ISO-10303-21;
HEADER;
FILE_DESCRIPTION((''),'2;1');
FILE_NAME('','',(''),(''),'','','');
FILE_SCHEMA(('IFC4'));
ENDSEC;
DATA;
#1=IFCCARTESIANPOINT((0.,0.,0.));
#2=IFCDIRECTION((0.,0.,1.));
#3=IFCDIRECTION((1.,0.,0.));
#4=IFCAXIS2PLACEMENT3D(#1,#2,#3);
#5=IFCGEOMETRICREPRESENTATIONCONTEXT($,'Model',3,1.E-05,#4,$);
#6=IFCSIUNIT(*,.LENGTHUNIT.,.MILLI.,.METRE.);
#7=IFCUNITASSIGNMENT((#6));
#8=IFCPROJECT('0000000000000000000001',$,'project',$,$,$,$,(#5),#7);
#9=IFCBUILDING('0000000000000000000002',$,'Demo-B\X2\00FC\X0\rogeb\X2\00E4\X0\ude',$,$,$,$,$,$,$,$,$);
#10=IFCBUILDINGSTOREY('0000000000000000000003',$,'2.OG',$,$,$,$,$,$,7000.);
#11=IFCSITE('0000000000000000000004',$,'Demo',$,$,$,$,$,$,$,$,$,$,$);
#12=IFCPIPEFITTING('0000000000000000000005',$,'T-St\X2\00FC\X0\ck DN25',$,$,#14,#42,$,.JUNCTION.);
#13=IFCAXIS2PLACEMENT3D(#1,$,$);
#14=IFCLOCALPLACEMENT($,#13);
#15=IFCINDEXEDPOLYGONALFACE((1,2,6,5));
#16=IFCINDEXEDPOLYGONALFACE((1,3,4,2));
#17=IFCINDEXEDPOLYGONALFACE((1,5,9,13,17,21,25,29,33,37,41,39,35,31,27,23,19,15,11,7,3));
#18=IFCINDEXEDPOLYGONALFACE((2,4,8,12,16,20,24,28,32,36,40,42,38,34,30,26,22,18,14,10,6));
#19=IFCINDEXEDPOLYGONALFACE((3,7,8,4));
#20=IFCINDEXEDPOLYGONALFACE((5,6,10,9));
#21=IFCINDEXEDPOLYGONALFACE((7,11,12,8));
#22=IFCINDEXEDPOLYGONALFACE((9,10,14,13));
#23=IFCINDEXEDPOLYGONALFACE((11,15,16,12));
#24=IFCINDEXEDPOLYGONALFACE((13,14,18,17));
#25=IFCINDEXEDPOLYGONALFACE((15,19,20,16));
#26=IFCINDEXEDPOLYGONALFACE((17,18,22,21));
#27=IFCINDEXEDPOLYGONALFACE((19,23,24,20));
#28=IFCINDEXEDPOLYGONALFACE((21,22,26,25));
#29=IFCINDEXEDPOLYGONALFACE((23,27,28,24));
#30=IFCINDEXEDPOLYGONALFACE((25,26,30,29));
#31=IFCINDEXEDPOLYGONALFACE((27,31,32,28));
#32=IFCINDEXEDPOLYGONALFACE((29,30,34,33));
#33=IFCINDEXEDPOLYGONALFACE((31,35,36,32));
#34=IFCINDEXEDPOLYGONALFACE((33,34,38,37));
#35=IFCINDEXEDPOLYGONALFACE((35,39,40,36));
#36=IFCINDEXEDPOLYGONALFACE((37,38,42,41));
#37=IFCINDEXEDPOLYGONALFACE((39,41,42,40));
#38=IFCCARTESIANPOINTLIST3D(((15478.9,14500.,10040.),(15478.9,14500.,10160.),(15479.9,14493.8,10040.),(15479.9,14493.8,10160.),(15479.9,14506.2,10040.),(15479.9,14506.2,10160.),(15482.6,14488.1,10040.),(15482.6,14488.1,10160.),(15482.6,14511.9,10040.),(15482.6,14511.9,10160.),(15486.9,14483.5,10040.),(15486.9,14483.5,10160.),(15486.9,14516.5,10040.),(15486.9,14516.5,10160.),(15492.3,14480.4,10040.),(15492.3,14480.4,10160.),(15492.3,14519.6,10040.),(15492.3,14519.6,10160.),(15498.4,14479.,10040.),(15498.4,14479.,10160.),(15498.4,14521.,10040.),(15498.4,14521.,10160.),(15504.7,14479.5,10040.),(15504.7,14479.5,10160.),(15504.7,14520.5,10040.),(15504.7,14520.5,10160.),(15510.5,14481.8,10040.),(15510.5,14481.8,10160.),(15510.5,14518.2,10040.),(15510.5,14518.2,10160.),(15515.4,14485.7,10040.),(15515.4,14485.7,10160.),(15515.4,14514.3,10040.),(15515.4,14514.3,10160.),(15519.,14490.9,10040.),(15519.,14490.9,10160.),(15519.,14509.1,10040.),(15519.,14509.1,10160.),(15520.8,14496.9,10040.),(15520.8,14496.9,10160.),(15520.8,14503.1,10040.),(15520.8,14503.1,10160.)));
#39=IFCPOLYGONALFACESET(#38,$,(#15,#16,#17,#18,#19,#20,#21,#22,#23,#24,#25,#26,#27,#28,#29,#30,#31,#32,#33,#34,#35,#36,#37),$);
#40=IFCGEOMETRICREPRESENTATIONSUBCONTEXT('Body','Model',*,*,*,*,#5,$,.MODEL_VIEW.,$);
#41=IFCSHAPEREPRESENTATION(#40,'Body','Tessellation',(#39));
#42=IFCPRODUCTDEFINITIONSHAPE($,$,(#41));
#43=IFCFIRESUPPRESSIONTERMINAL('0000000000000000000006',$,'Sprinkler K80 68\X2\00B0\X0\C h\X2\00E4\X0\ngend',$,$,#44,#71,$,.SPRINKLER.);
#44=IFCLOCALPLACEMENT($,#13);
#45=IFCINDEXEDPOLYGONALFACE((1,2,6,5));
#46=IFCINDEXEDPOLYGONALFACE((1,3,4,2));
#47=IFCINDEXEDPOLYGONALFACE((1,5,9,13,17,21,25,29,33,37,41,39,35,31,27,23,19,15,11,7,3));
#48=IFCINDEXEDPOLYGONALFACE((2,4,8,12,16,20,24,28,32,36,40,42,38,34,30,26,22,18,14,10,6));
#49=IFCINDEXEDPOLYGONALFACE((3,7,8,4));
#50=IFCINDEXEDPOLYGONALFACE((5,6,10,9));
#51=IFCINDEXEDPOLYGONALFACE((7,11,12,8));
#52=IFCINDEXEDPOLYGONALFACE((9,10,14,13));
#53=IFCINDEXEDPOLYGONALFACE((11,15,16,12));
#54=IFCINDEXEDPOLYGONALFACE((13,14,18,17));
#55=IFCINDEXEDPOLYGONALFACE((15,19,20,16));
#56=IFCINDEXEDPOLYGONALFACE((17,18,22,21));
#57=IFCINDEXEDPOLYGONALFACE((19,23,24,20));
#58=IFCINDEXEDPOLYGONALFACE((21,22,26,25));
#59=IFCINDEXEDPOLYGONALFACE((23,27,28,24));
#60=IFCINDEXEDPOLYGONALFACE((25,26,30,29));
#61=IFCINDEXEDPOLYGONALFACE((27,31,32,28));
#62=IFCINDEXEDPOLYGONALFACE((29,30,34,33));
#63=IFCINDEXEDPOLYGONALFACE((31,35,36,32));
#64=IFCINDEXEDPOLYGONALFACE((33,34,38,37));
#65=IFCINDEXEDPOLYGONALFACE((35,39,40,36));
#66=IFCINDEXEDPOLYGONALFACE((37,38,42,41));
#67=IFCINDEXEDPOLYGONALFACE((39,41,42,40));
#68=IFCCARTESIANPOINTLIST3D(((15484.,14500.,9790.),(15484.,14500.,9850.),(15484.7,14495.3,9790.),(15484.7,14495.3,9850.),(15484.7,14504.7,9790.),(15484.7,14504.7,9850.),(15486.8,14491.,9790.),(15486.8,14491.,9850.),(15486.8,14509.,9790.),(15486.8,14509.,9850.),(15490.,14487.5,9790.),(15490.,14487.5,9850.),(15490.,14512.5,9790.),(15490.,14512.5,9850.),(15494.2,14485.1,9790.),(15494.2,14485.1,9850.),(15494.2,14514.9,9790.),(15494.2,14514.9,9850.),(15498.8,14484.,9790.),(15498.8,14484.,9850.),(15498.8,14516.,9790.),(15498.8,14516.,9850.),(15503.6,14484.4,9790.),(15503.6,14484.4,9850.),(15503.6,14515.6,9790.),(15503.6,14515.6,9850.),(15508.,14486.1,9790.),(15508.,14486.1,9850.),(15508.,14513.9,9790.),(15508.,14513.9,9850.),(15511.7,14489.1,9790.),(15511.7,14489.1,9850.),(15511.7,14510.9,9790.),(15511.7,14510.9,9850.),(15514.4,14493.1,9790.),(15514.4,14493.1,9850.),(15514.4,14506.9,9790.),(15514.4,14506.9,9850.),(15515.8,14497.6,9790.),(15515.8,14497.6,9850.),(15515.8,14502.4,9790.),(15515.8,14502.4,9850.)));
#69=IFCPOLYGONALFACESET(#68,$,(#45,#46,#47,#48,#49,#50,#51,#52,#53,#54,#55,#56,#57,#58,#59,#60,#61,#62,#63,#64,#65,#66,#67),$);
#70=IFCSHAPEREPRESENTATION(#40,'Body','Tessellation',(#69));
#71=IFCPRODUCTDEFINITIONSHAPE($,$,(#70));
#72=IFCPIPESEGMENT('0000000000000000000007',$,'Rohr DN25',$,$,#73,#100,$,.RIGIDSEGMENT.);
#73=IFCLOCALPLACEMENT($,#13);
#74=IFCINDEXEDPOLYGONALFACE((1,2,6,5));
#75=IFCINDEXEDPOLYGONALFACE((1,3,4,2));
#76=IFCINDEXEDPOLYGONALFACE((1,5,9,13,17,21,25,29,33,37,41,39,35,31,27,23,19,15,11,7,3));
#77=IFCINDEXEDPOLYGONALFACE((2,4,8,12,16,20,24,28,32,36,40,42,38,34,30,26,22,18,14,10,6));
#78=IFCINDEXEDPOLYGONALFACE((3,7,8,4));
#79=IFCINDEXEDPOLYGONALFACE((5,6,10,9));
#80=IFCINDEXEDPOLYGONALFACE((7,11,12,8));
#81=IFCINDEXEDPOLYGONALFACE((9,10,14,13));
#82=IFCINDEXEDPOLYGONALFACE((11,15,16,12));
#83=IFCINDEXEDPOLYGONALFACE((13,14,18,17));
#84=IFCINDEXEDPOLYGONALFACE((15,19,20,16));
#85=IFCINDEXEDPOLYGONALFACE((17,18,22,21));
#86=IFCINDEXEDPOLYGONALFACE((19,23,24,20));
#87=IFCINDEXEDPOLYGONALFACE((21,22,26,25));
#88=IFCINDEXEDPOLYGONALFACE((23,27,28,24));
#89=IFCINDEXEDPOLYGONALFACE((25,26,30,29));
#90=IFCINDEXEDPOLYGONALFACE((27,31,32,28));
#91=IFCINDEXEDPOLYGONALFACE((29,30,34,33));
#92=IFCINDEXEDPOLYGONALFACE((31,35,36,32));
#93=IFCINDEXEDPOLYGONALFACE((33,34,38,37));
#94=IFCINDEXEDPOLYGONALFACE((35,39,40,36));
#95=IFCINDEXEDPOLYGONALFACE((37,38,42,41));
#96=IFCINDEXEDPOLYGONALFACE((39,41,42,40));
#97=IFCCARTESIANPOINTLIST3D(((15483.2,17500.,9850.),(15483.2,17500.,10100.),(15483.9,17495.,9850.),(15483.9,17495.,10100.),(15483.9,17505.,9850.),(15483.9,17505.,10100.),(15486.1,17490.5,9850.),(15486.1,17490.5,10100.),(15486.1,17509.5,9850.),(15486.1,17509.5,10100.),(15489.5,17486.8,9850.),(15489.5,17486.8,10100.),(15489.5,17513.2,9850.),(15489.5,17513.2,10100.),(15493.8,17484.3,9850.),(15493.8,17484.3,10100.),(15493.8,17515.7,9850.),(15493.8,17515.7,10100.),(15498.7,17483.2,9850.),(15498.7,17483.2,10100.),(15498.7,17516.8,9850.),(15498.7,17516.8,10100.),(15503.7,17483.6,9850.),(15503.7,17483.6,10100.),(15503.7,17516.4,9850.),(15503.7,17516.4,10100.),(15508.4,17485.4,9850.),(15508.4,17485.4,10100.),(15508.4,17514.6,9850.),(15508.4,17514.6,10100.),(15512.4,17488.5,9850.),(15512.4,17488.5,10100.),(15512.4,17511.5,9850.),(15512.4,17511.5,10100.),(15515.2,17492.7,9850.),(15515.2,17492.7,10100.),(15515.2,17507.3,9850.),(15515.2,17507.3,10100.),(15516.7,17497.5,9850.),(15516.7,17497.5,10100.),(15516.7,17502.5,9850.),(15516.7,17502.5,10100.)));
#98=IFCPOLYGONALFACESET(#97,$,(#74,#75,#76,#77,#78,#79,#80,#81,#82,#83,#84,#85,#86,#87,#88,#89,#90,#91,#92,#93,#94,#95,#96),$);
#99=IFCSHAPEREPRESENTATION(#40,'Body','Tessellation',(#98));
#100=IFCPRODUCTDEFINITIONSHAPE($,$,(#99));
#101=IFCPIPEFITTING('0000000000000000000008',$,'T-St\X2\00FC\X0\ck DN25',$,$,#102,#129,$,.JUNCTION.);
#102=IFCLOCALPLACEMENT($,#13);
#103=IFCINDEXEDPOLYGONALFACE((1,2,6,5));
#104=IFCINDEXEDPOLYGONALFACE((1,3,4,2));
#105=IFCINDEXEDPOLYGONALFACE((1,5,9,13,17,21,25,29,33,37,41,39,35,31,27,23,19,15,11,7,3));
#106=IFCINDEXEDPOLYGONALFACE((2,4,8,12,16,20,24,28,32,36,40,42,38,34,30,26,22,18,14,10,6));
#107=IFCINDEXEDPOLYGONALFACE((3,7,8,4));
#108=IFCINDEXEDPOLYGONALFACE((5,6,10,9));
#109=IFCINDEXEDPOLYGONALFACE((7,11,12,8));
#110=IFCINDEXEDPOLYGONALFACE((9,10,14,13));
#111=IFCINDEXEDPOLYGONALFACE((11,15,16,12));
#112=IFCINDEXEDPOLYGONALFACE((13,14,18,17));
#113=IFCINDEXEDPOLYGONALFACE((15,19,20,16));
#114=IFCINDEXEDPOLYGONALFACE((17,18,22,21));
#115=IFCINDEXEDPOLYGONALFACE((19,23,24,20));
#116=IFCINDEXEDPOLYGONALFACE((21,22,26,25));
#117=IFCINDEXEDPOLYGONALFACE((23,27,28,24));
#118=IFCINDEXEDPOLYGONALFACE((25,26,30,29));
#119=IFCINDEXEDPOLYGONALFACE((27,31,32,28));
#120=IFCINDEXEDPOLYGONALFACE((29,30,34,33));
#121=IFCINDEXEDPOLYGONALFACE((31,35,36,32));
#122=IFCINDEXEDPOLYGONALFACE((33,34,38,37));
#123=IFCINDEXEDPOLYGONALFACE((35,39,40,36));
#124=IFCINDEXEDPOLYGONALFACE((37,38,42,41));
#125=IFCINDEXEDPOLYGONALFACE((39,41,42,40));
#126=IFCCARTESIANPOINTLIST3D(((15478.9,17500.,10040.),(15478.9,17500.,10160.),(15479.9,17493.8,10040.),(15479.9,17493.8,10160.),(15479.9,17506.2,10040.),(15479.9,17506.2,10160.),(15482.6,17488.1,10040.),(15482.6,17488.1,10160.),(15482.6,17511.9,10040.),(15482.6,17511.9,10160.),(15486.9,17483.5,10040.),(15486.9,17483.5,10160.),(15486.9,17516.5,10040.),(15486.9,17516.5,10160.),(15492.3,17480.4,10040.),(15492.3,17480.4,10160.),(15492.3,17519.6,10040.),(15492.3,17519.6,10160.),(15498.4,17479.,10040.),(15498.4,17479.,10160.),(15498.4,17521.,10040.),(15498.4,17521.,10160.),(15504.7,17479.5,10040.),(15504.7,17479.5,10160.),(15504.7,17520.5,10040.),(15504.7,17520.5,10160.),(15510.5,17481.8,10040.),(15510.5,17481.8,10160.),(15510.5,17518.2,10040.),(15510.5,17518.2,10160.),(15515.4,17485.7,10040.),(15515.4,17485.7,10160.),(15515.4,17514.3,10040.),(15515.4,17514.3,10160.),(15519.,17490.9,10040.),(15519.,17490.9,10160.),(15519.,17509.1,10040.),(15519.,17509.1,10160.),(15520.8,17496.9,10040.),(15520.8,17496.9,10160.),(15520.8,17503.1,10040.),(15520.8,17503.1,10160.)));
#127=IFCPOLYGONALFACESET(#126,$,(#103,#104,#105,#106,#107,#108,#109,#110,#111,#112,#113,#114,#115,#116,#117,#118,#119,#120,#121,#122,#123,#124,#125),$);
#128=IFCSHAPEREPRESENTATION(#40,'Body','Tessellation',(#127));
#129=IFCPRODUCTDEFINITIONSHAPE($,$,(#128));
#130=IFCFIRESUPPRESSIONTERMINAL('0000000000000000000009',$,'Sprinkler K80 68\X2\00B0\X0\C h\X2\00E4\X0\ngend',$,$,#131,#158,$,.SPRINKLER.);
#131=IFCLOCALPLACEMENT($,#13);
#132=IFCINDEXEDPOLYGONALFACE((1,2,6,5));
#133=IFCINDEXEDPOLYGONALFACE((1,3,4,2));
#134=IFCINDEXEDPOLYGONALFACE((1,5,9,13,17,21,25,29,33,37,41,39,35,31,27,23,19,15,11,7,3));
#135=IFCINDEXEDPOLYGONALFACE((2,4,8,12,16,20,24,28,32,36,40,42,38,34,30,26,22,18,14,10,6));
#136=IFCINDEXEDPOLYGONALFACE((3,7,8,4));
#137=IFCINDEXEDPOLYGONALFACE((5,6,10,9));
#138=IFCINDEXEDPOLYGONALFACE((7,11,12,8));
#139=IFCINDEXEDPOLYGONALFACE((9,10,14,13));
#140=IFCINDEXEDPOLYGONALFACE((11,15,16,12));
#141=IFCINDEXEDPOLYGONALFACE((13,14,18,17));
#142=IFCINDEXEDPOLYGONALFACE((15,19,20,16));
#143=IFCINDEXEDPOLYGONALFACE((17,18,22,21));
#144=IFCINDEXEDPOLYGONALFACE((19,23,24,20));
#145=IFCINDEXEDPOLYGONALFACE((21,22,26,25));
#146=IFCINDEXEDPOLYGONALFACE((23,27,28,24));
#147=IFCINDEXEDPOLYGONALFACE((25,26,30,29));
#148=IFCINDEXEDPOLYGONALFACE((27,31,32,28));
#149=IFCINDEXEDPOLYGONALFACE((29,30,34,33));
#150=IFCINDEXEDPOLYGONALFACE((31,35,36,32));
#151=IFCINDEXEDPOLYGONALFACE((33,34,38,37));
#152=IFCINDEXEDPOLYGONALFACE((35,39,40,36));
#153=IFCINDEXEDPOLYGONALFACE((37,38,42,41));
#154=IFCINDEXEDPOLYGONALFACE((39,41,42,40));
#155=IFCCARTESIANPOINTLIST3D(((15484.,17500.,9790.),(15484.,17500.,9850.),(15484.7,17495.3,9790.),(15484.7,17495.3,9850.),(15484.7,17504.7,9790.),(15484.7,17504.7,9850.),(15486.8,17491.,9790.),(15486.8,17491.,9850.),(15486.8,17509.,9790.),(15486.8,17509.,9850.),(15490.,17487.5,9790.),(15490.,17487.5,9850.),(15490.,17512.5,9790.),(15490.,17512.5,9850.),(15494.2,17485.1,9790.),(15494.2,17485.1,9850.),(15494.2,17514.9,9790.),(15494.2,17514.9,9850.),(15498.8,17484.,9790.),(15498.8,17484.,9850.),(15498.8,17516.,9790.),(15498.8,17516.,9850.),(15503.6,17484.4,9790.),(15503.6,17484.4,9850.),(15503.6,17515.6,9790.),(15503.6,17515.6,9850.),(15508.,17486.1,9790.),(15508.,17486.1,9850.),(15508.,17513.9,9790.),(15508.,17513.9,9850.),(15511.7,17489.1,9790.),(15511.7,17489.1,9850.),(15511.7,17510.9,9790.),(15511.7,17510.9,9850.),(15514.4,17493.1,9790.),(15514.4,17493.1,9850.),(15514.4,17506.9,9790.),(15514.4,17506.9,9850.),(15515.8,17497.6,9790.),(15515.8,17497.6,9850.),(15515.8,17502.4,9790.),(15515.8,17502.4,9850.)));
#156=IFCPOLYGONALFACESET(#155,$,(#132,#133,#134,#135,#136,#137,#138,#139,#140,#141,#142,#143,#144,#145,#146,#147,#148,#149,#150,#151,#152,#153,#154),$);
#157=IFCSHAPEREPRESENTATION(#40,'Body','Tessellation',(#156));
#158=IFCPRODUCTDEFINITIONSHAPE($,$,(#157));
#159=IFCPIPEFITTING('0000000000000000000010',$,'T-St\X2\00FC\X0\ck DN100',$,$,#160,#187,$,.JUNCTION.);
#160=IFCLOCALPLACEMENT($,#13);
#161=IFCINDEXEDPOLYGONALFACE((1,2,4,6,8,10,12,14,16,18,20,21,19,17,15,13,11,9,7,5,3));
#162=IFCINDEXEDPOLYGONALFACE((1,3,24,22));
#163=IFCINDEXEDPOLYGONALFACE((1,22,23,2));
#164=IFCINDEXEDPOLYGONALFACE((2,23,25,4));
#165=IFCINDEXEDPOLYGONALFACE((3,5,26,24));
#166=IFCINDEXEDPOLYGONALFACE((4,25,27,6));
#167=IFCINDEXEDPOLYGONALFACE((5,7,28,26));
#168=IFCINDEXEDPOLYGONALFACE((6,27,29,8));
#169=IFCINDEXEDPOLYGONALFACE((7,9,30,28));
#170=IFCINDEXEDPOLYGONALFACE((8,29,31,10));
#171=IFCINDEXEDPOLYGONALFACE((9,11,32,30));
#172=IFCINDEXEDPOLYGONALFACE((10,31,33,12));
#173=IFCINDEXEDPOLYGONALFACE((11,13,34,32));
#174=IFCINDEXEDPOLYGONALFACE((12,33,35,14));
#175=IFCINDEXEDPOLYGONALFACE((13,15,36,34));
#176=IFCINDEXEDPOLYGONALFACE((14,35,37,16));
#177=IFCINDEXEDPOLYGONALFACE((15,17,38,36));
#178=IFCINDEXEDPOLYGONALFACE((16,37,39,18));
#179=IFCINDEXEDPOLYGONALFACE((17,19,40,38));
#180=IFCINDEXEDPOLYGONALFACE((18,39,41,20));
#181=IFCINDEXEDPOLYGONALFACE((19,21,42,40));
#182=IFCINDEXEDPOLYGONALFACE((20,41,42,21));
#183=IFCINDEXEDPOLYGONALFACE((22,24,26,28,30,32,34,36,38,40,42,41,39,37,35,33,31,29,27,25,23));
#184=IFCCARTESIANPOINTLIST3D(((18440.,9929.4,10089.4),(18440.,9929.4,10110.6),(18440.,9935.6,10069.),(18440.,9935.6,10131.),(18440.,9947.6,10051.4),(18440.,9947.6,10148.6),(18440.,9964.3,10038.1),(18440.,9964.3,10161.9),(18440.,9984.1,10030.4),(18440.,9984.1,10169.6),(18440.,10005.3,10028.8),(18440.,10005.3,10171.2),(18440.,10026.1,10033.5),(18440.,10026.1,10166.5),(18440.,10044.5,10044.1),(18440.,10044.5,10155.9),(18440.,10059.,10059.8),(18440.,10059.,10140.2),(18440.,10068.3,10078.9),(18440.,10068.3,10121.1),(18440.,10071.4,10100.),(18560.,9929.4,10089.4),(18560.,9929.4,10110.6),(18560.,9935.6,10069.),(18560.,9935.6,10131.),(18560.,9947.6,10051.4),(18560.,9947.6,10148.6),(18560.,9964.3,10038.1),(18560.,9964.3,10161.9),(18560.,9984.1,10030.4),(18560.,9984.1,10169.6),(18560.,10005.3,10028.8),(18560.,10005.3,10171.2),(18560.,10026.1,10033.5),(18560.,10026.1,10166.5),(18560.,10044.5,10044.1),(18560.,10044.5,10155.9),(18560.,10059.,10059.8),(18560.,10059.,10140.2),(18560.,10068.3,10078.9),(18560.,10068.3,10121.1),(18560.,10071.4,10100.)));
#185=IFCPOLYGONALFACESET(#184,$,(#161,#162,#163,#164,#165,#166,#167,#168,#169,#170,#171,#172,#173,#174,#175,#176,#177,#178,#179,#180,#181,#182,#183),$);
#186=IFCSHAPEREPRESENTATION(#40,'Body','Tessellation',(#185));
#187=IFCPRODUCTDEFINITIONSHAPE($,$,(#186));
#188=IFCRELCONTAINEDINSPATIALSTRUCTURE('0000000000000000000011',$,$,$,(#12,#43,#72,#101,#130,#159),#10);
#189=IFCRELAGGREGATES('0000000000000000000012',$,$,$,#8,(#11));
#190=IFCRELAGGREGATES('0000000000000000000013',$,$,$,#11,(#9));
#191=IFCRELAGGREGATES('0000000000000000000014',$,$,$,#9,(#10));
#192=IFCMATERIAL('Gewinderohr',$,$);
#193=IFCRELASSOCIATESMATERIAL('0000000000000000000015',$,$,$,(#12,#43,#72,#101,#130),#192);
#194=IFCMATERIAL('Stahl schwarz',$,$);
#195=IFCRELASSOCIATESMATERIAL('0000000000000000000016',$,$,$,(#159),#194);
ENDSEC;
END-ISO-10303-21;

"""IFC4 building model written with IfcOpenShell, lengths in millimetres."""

from ifc_helpers import new_model, si_unit, frame, origin_with_axes, place, context, subcontext, project, spatial, circle, extrude, material, element, save


model = new_model("IFC4")

# Units and contexts
model_context = context("Model", 3, precision=1e-05, world=origin_with_axes())
body_context = subcontext(model_context, "Body", "Model", "MODEL_VIEW")
ifc_project = project(units=[si_unit("LENGTHUNIT", "METRE", prefix="MILLI")], contexts=[model_context])

# Site, building, storey
site = spatial("IfcSite", under=ifc_project, Name="Demo")
building = spatial("IfcBuilding", under=site, Name="Demo-Bürogebäude")
storey = spatial("IfcBuildingStorey", under=building, Name="2.OG", Elevation=7000.0)

# Pipe fitting
ifc_material_1 = material(Name="Gewinderohr")
pipe_fitting_1_placement = place(None, frame((15500.0, 14500.0, 10160.0), z_axis=(0.0, 0.0, -1.0), x_axis=(-1.0, 0.0, 0.0)))
element("IfcPipeFitting", 1, at=pipe_fitting_1_placement, inside=storey, material=ifc_material_1, Name="T-Stück DN25", PredefinedType="JUNCTION", context=body_context, shape_type="SweptSolid", body=[
    extrude(circle(Radius=21.1), origin_with_axes(), (0.0, 0.0, 1.0), 120.0),
])

# Fire suppression terminal
fire_suppression_terminal_1_placement = place(None, frame((15500.0, 14500.0, 9850.0), z_axis=(0.0, 0.0, -1.0), x_axis=(-1.0, 0.0, 0.0)))
element("IfcFireSuppressionTerminal", 2, at=fire_suppression_terminal_1_placement, inside=storey, material=ifc_material_1, Name="Sprinkler K80 68°C hängend", PredefinedType="SPRINKLER", context=body_context, shape_type="SweptSolid", body=[
    extrude(circle(Radius=16.0), origin_with_axes(), (0.0, 0.0, 1.0), 60.0),
])

# Pipe segment
pipe_segment_1_placement = place(None, frame((15500.0, 17500.0, 10100.0), z_axis=(0.0, 0.0, -1.0), x_axis=(-1.0, 0.0, 0.0)))
element("IfcPipeSegment", 3, at=pipe_segment_1_placement, inside=storey, material=ifc_material_1, Name="Rohr DN25", PredefinedType="RIGIDSEGMENT", context=body_context, shape_type="SweptSolid", body=[
    extrude(circle(Radius=16.9), origin_with_axes(), (0.0, 0.0, 1.0), 250.0),
])

# Pipe fitting
pipe_fitting_2_placement = place(None, frame((15500.0, 17500.0, 10160.0), z_axis=(0.0, 0.0, -1.0), x_axis=(-1.0, 0.0, 0.0)))
element("IfcPipeFitting", 4, at=pipe_fitting_2_placement, inside=storey, material=ifc_material_1, Name="T-Stück DN25", PredefinedType="JUNCTION", context=body_context, shape_type="SweptSolid", body=[
    extrude(circle(Radius=21.1), origin_with_axes(), (0.0, 0.0, 1.0), 120.0),
])

# Fire suppression terminal
fire_suppression_terminal_2_placement = place(None, frame((15500.0, 17500.0, 9850.0), z_axis=(0.0, 0.0, -1.0), x_axis=(-1.0, 0.0, 0.0)))
element("IfcFireSuppressionTerminal", 5, at=fire_suppression_terminal_2_placement, inside=storey, material=ifc_material_1, Name="Sprinkler K80 68°C hängend", PredefinedType="SPRINKLER", context=body_context, shape_type="SweptSolid", body=[
    extrude(circle(Radius=16.0), origin_with_axes(), (0.0, 0.0, 1.0), 60.0),
])

# Pipe fitting
ifc_material_2 = material(Name="Stahl schwarz")
pipe_fitting_3_placement = place(None, frame((18440.0, 10000.0, 10100.0), z_axis=(1.0, 0.0, 0.0), x_axis=(0.0, 1.0, 0.0)))
element("IfcPipeFitting", 6, at=pipe_fitting_3_placement, inside=storey, material=ifc_material_2, Name="T-Stück DN100", PredefinedType="JUNCTION", context=body_context, shape_type="SweptSolid", body=[
    extrude(circle(Radius=71.4), origin_with_axes(), (0.0, 0.0, 1.0), 120.0),
])

save(model, "model.ifc")
